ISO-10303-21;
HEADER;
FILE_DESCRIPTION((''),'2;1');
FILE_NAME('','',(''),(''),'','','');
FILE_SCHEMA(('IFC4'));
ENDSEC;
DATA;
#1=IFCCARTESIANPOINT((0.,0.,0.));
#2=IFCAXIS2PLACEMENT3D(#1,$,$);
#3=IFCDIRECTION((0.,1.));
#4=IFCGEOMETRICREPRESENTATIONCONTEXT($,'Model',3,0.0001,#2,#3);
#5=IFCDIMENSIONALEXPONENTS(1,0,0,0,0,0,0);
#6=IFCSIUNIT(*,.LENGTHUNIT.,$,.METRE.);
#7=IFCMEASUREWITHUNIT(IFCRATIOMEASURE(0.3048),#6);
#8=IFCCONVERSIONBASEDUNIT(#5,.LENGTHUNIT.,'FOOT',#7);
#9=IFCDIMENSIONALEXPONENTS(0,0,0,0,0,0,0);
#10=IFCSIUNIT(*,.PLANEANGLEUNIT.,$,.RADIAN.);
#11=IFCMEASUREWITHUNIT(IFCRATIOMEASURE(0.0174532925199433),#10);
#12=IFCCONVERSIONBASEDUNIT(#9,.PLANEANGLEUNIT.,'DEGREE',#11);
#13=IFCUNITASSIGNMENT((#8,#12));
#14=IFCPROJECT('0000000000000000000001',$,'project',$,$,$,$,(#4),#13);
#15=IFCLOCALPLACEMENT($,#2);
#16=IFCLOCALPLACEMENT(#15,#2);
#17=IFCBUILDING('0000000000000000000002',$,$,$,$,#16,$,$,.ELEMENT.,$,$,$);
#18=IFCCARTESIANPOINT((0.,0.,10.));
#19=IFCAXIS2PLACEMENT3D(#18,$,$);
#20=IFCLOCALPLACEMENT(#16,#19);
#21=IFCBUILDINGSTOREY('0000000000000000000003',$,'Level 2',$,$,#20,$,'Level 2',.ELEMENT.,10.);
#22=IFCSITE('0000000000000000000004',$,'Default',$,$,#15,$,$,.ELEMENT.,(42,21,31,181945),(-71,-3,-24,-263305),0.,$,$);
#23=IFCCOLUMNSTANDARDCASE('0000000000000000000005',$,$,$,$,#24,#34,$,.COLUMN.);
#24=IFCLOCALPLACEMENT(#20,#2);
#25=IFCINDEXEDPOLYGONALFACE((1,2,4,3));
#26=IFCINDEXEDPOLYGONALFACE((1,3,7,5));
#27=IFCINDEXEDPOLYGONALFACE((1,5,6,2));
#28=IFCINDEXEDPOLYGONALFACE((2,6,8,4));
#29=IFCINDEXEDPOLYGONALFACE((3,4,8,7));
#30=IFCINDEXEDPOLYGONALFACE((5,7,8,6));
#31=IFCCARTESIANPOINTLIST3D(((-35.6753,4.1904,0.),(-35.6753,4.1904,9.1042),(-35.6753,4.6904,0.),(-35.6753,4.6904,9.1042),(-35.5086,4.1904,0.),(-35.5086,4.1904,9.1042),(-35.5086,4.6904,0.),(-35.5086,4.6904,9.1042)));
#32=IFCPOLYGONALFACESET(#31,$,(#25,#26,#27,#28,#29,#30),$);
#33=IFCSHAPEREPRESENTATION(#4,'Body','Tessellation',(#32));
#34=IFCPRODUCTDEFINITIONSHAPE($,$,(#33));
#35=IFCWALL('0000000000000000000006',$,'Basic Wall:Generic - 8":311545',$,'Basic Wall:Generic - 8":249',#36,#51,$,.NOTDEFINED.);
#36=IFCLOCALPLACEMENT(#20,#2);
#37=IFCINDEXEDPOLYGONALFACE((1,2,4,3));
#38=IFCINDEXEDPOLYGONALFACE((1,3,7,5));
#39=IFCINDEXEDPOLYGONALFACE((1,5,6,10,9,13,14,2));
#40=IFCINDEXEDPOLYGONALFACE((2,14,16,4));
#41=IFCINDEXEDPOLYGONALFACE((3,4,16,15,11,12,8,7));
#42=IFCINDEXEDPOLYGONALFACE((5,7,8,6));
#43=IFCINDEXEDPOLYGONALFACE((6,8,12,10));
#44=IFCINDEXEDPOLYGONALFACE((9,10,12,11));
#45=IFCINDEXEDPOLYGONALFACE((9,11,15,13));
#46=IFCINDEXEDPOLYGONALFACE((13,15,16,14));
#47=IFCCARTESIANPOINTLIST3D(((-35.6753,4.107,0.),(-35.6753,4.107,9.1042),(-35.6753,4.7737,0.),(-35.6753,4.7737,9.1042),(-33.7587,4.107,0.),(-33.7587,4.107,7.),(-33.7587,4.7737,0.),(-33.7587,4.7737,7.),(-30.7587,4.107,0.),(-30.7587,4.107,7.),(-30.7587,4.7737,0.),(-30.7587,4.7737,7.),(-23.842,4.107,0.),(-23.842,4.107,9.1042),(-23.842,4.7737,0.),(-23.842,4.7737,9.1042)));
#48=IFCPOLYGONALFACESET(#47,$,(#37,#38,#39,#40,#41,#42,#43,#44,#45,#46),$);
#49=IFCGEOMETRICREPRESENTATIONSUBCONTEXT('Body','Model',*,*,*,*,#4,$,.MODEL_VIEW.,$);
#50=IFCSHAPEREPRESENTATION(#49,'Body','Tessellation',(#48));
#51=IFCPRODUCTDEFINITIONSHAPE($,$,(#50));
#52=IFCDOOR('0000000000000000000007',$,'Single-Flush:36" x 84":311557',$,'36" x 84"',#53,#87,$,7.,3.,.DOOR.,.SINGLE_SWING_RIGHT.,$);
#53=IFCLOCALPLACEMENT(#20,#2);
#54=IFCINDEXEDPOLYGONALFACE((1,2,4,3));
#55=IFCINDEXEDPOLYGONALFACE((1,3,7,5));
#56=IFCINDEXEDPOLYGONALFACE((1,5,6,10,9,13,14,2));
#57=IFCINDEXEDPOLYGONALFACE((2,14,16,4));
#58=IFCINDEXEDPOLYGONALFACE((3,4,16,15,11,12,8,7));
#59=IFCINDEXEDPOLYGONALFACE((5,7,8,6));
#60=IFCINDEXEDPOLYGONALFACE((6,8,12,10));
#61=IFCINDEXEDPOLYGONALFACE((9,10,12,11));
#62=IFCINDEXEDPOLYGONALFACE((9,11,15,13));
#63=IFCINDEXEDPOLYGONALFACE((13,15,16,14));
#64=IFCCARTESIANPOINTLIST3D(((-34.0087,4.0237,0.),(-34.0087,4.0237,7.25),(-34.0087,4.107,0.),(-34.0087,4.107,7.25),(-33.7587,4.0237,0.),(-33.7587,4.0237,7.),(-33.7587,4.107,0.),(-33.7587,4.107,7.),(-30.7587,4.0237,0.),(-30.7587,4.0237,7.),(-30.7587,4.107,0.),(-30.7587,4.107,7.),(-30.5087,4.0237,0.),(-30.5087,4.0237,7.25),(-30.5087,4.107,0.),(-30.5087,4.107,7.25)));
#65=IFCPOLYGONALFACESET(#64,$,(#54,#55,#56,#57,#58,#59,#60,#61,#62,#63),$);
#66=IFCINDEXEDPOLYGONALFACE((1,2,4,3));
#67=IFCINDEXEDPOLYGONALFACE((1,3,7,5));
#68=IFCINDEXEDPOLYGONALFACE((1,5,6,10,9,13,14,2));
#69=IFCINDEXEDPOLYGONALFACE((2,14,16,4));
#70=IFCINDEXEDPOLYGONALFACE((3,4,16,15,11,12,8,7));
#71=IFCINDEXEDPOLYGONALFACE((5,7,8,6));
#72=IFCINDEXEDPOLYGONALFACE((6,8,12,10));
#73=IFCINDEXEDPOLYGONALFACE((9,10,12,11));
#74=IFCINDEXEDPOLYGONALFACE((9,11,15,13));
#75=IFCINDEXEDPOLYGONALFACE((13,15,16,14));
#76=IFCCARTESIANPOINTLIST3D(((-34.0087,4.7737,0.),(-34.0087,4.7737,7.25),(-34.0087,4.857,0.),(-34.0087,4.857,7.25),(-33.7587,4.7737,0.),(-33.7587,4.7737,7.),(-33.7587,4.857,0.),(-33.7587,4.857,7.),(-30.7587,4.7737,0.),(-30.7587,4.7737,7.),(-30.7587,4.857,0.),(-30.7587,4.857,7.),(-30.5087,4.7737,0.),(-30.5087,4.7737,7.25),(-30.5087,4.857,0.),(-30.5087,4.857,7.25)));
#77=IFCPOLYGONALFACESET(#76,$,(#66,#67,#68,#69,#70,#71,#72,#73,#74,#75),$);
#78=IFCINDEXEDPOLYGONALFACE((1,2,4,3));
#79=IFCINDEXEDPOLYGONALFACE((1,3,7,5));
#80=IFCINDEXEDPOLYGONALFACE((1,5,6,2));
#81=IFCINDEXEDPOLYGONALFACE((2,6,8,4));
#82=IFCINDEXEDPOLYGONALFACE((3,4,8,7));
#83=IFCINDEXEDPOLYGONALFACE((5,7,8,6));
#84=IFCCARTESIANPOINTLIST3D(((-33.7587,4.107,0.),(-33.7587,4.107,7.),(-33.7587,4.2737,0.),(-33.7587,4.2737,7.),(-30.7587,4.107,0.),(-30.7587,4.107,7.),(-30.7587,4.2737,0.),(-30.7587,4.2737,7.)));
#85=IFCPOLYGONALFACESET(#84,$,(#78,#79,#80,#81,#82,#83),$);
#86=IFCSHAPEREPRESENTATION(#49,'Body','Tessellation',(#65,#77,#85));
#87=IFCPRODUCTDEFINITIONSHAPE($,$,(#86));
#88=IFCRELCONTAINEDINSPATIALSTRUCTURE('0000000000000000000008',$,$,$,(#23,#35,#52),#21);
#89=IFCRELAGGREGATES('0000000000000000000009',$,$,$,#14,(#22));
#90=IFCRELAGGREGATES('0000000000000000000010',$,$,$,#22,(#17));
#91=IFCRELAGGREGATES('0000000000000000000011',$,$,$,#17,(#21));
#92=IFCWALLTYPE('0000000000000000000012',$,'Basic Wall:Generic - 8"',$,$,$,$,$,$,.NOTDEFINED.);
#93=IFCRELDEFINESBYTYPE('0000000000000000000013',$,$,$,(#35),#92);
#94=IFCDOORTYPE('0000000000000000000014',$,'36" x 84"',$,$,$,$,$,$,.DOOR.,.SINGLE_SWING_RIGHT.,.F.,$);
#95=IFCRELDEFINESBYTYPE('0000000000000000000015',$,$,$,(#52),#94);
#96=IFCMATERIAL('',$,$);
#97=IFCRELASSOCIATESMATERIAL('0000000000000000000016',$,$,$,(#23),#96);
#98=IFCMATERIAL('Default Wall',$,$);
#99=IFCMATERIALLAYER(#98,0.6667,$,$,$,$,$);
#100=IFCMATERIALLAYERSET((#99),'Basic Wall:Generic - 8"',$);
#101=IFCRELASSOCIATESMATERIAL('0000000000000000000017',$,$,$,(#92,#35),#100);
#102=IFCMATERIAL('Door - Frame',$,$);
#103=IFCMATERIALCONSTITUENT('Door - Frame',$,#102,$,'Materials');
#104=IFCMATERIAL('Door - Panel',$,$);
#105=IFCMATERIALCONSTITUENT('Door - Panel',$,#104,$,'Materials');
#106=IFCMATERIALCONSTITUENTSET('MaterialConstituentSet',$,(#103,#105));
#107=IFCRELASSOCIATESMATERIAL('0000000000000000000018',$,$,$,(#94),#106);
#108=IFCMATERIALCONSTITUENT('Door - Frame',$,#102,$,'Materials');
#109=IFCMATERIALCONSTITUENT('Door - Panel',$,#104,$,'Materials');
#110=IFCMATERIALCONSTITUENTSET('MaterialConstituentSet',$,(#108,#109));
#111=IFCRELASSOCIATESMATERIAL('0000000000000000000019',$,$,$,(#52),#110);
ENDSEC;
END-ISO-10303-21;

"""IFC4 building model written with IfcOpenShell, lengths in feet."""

from ifc_helpers import new_model, entity, si_unit, converted_unit, direction, frame, frame_2d, origin, place, context, subcontext, project, spatial, polyline, rectangle, outline, extrude, clip, bounded_halfspace, source, transform, mapped, material, layer, layer_set, layer_usage, constituent, constituent_set, type_object, type_shapes, element, fill, save


model = new_model("IFC4")

# Units and contexts
model_context = context("Model", 3, precision=0.0001, world=origin(), true_north=direction((0.0, 1.0)))
body_context = subcontext(model_context, "Body", "Model", "MODEL_VIEW")
ifc_project = project(units=[converted_unit("LENGTHUNIT", "FOOT", entity("IfcRatioMeasure", 0.3048), si_unit("LENGTHUNIT", "METRE"), dimensions=[1, 0, 0, 0, 0, 0, 0]), converted_unit("PLANEANGLEUNIT", "DEGREE", entity("IfcRatioMeasure", 0.0174532925199433), si_unit("PLANEANGLEUNIT", "RADIAN"), dimensions=[0, 0, 0, 0, 0, 0, 0])], contexts=[model_context])

# Site, building, storey
site_placement = place(None, origin())
site = spatial("IfcSite", under=ifc_project, at=site_placement, Name="Default", CompositionType="ELEMENT", RefLatitude=(42, 21, 31, 181945), RefLongitude=(-71, -3, -24, -263305), RefElevation=0.0)
building_placement = place(site_placement, origin())
building = spatial("IfcBuilding", under=site, at=building_placement, CompositionType="ELEMENT")
storey_placement = place(building_placement, frame((0.0, 0.0, 10.0)))
storey = spatial("IfcBuildingStorey", under=building, at=storey_placement, Name="Level 2", LongName="Level 2", CompositionType="ELEMENT", Elevation=10.0)

# Column
ifc_material_1 = material(Name="")
wall_placement = place(storey_placement, frame((-35.6753, 4.4404, 0.0)))
column_placement = place(wall_placement, frame((0.0833, 0.0, 0.0), z_axis=(0.0, 0.0, 1.0), x_axis=(1.0, 0.0, 0.0)))
element("IfcColumnStandardCase", 1, at=column_placement, inside=storey, material=ifc_material_1, PredefinedType="COLUMN", context=model_context, shape_type="SweptSolid", body=[
    extrude(rectangle(XDim=0.1667, YDim=0.5), origin(), (0.0, 0.0, 1.0), 9.1042),
])

# Wall, opening, door
ifc_material_2 = material(Name="Default Wall")
ifc_layer = layer(ifc_material_2, 0.6667)
ifc_layer_set = layer_set([ifc_layer], Name="Basic Wall:Generic - 8\"")
ifc_layer_usage = layer_usage(ifc_layer_set, "AXIS2", "NEGATIVE", 0.3333)
wall_type = type_object("IfcWallType", Name="Basic Wall:Generic - 8\"", PredefinedType="NOTDEFINED", material=ifc_layer_set)
wall = element("IfcWall", 2, at=wall_placement, inside=storey, type_object=wall_type, material=ifc_layer_usage, Name="Basic Wall:Generic - 8\":311545", ObjectType="Basic Wall:Generic - 8\":249", PredefinedType="NOTDEFINED", context=body_context, shape_type="Clipping", body=[
    clip(extrude(rectangle(XDim=11.8333, YDim=0.6667, at=frame_2d((5.9167, 0.0), x_axis=(-1.0, 0.0))), origin(), (0.0, 0.0, 1.0), 9.1042), bounded_halfspace(frame((0.0, -0.3333, 9.1042), z_axis=(0.0, 0.0, -1.0), x_axis=(0.0, -1.0, 0.0)), True, frame((0.0, -0.3333, 9.1042), z_axis=(0.0, 0.0, -1.0), x_axis=(0.0, -1.0, 0.0)), polyline([(0.0, 0.0), (-0.6667, 0.0), (-0.6667, -11.8333), (0.0, -11.8333), (0.0, 0.0)]))),
])
opening_placement = place(wall_placement, frame((4.9167, 0.3333, 0.0)))
opening = element("IfcOpeningElement", 3, at=opening_placement, cuts=wall, ObjectType="Opening", PredefinedType="OPENING", context=body_context, shape_type="SweptSolid", body=[
    extrude(rectangle(XDim=3.0, YDim=7.0, at=frame_2d((3.5, 1.5), x_axis=(0.0, 1.0))), frame((0.0, 0.0, 0.0), z_axis=(0.0, -1.0, 0.0), x_axis=(0.0, 0.0, 1.0)), (0.0, 0.0, 1.0), 0.6667),
])
ifc_material_3 = material(Name="Door - Frame")
ifc_constituent_1 = constituent(ifc_material_3, Name="Door - Frame", Category="Materials")
ifc_material_4 = material(Name="Door - Panel")
ifc_constituent_2 = constituent(ifc_material_4, Name="Door - Panel", Category="Materials")
ifc_constituent_set_1 = constituent_set(constituents=[ifc_constituent_1, ifc_constituent_2], Name="MaterialConstituentSet")
ifc_constituent_3 = constituent(ifc_material_3, Name="Door - Frame", Category="Materials")
ifc_constituent_4 = constituent(ifc_material_4, Name="Door - Panel", Category="Materials")
ifc_constituent_set_2 = constituent_set(constituents=[ifc_constituent_3, ifc_constituent_4], Name="MaterialConstituentSet")
door_type = type_object("IfcDoorType", Name="36\" x 84\"", OperationType="SINGLE_SWING_RIGHT", ParameterTakesPrecedence=False, PredefinedType="DOOR", material=ifc_constituent_set_2)
shared_shape = source(origin(), body_context, "Body", "SweptSolid", [
    extrude(outline(polyline([(-1.75, -3.6875), (1.75, -3.6875), (1.75, 3.5625), (1.5, 3.5625), (1.5, -3.4375), (-1.5, -3.4375), (-1.5, 3.5625), (-1.75, 3.5625), (-1.75, -3.6875)])), frame((1.5, 0.6667, 3.5625), z_axis=(0.0, 1.0, 0.0), x_axis=(1.0, 0.0, 0.0)), (0.0, 0.0, 1.0), 0.0833),
    extrude(outline(polyline([(-3.6875, -1.75), (3.5625, -1.75), (3.5625, -1.5), (-3.4375, -1.5), (-3.4375, 1.5), (3.5625, 1.5), (3.5625, 1.75), (-3.6875, 1.75), (-3.6875, -1.75)])), frame((1.5, -0.0833, 3.5625), z_axis=(0.0, 1.0, 0.0), x_axis=(0.0, 0.0, -1.0)), (0.0, 0.0, 1.0), 0.0833),
    extrude(rectangle(XDim=0.1667, YDim=3.0, at=frame_2d((0.0, 0.0), x_axis=(1.0, 0.0))), frame((1.5, 0.5833, 0.0), z_axis=(0.0, 0.0, 1.0), x_axis=(0.0, 1.0, 0.0)), (0.0, 0.0, 1.0), 7.0),
])
type_shapes(door_type, [shared_shape])
door_placement = place(opening_placement, frame((0.0, 0.0, 0.0), z_axis=(0.0, 0.0, 1.0), x_axis=(-1.0, 0.0, 0.0)))
door = element("IfcDoor", 4, at=door_placement, inside=storey, type_object=door_type, material=ifc_constituent_set_1, Name="Single-Flush:36\" x 84\":311557", ObjectType="36\" x 84\"", OperationType="SINGLE_SWING_RIGHT", OverallHeight=7.0, OverallWidth=3.0, PredefinedType="DOOR", context=body_context, shape_type="MappedRepresentation", body=[
    mapped(shared_shape, transform((0.0, 0.0, 0.0), scale=1.0)),
])
fill(opening, door)

save(model, "model.ifc")
